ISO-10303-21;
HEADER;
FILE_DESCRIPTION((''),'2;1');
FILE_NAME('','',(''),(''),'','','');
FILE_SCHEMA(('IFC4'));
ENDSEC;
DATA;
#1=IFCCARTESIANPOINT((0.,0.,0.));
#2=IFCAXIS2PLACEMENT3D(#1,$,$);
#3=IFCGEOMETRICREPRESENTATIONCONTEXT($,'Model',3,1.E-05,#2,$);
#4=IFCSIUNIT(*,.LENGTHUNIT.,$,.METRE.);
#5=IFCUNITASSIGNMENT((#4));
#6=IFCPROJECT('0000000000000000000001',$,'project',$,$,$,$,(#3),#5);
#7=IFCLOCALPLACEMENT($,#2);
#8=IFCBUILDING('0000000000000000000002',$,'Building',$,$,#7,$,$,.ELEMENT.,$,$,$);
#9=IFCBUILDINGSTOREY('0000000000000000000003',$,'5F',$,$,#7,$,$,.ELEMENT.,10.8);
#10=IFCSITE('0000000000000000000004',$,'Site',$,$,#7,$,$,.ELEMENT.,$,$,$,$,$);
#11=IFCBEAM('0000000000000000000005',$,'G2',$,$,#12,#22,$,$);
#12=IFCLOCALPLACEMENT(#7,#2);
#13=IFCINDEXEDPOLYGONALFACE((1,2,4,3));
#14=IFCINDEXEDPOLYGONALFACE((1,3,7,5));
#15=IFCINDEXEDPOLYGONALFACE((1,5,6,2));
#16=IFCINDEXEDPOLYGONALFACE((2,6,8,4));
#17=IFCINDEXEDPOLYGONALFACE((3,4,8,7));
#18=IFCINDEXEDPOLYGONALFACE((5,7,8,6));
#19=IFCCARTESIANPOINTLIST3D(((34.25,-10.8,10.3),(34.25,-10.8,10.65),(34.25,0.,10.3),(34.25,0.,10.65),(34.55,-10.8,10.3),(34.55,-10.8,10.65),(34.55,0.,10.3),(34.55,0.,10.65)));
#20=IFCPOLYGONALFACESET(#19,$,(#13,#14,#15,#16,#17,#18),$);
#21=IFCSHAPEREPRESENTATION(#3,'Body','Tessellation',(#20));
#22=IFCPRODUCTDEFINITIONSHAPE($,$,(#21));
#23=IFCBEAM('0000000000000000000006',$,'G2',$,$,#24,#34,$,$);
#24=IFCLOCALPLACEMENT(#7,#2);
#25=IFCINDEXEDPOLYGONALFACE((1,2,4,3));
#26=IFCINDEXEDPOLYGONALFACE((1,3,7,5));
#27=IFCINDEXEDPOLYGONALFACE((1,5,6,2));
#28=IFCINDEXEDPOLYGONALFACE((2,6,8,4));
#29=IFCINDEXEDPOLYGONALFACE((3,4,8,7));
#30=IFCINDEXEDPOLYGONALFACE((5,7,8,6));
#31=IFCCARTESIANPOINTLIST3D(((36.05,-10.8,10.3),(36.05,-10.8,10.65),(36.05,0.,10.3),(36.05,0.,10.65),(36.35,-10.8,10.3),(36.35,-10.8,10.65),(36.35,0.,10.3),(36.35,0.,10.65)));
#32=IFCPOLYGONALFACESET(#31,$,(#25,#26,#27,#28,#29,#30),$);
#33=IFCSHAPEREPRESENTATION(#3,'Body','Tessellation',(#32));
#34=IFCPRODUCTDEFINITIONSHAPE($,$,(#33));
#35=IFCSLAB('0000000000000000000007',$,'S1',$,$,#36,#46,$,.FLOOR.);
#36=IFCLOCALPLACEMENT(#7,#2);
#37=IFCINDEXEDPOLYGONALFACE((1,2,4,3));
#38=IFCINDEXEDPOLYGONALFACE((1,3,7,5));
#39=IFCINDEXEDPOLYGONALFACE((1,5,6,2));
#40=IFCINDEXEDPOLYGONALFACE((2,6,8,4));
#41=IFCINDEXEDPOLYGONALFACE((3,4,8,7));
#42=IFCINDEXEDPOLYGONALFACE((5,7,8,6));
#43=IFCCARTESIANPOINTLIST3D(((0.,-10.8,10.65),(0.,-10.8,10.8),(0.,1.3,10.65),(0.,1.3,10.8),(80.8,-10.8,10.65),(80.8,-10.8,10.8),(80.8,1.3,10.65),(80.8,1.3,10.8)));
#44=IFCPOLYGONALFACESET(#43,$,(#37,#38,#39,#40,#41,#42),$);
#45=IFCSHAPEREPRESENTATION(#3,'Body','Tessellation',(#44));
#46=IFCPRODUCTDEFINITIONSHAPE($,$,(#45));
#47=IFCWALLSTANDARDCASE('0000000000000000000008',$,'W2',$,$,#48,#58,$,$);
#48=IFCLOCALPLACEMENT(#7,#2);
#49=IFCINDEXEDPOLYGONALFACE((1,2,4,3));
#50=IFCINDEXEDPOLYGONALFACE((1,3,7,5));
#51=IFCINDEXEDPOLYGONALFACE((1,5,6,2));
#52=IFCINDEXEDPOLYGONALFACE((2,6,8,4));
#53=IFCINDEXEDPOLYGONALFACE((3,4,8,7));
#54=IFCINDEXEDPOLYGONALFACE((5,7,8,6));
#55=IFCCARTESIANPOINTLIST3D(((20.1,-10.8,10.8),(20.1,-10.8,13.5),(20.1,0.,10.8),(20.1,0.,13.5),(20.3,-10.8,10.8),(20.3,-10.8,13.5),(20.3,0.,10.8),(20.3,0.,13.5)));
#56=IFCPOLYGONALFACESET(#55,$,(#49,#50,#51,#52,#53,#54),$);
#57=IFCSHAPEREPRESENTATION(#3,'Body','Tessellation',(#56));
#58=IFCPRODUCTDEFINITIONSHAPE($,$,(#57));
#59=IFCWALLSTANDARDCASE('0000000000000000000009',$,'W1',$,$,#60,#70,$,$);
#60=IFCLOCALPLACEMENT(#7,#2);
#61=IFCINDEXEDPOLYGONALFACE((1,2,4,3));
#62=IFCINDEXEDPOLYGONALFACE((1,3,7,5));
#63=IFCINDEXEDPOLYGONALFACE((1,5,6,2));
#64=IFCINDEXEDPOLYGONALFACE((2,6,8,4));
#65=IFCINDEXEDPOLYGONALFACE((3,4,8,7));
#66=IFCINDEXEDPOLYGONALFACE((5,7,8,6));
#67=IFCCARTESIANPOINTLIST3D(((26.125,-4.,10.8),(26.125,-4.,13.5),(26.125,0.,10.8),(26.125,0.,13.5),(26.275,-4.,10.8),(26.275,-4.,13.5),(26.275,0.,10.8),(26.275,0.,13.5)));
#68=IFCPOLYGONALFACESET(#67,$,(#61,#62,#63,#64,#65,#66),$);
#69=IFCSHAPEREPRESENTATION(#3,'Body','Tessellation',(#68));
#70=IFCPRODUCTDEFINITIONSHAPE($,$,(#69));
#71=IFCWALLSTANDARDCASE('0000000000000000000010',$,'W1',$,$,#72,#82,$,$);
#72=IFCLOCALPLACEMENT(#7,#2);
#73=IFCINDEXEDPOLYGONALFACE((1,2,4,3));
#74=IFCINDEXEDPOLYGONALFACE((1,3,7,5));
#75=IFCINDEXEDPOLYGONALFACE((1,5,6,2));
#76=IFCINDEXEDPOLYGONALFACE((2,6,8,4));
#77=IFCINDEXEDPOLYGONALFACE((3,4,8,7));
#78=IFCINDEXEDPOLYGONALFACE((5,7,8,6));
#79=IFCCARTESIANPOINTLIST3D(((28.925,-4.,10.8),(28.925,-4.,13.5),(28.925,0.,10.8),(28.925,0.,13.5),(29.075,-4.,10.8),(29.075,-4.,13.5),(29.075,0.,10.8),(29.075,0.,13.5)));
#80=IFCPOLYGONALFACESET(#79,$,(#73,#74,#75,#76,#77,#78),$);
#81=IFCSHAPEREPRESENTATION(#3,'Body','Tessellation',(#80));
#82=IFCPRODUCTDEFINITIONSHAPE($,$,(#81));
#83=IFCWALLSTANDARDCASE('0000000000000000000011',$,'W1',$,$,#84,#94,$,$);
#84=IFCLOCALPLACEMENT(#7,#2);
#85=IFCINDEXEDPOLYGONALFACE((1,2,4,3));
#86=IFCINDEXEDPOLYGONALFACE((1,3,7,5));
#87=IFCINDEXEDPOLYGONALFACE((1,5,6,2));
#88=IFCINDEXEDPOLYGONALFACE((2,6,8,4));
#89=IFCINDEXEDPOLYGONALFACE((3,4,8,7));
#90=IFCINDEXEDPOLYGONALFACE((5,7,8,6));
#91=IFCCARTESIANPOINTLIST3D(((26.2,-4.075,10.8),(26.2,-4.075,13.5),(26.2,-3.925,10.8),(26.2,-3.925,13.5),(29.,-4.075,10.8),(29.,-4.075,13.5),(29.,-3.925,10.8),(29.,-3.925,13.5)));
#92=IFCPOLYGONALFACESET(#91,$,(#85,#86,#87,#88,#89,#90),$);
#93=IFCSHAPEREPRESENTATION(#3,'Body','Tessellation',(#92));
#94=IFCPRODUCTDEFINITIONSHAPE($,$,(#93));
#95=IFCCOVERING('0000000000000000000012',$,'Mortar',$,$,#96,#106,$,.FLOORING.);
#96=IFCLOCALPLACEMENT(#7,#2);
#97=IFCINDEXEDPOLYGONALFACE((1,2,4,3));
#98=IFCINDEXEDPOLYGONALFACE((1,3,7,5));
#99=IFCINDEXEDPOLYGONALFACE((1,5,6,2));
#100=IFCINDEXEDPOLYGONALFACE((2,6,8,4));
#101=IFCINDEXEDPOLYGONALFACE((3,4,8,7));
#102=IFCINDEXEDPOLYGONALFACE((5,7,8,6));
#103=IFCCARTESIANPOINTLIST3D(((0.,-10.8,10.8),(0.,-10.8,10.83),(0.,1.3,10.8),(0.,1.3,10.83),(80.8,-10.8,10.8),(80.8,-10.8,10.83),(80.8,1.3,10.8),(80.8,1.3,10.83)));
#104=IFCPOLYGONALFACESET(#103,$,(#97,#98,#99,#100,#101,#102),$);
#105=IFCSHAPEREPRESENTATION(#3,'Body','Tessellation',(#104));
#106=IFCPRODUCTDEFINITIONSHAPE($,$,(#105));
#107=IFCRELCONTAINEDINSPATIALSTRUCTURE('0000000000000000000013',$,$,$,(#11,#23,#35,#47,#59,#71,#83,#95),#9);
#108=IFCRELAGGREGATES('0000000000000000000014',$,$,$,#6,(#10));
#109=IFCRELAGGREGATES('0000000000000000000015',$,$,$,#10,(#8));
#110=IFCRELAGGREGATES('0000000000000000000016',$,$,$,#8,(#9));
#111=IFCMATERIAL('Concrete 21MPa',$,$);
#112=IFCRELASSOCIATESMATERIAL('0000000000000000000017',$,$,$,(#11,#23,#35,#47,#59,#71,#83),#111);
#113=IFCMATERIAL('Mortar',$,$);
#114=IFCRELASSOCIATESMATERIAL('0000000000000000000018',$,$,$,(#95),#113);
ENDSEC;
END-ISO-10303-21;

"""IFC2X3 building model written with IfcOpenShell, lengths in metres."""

from ifc_helpers import new_model, si_unit, frame, origin, origin_2d, place, context, project, spatial, rectangle, extrude, material, element, save


model = new_model("IFC2X3")

# Units and contexts
model_context = context("Model", 3, precision=1e-05, world=origin())
ifc_project = project(units=[si_unit("LENGTHUNIT", "METRE")], contexts=[model_context])

# Site, building, storey
placement = place(None, origin())
site = spatial("IfcSite", under=ifc_project, at=placement, Name="Site", CompositionType="ELEMENT")
building = spatial("IfcBuilding", under=site, at=placement, Name="Building", CompositionType="ELEMENT")
storey = spatial("IfcBuildingStorey", under=building, at=placement, Name="5F", CompositionType="ELEMENT", Elevation=10.8)

# Shared definitions
ifc_material_1 = material(Name="Concrete 21MPa")

# Beams
for number, where, name in (
    (1, (34.4, -5.4, 10.3), "G2"),
    (2, (36.2, -5.4, 10.3), "G2"),
):
    element("IfcBeam", number, at=place(None, frame(where)), inside=storey, material=ifc_material_1, Name=name, context=model_context, shape_type="SweptSolid", body=[
        extrude(rectangle(XDim=0.3, YDim=10.8, at=origin_2d()), origin(), (0.0, 0.0, 1.0), 0.35),
    ])

# Slab
slab_placement = place(None, frame((40.4, -4.75, 10.65)))
element("IfcSlab", 3, at=slab_placement, inside=storey, material=ifc_material_1, Name="S1", PredefinedType="FLOOR", context=model_context, shape_type="SweptSolid", body=[
    extrude(rectangle(XDim=80.8, YDim=12.1, at=origin_2d()), origin(), (0.0, 0.0, 1.0), 0.15),
])

# Walls
wall_1_placement = place(None, frame((20.2, -5.4, 10.8)))
element("IfcWallStandardCase", 4, at=wall_1_placement, inside=storey, material=ifc_material_1, Name="W2", context=model_context, shape_type="SweptSolid", body=[
    extrude(rectangle(XDim=0.2, YDim=10.8, at=origin_2d()), origin(), (0.0, 0.0, 1.0), 2.7),
])
for number, where, name in (
    (5, (26.2, -2.0, 10.8), "W1"),
    (6, (29.0, -2.0, 10.8), "W1"),
):
    element("IfcWallStandardCase", number, at=place(None, frame(where)), inside=storey, material=ifc_material_1, Name=name, context=model_context, shape_type="SweptSolid", body=[
        extrude(rectangle(XDim=0.15, YDim=4.0, at=origin_2d()), origin(), (0.0, 0.0, 1.0), 2.7),
    ])
wall_2_placement = place(None, frame((27.6, -4.0, 10.8)))
element("IfcWallStandardCase", 7, at=wall_2_placement, inside=storey, material=ifc_material_1, Name="W1", context=model_context, shape_type="SweptSolid", body=[
    extrude(rectangle(XDim=2.8, YDim=0.15, at=origin_2d()), origin(), (0.0, 0.0, 1.0), 2.7),
])

# Covering
ifc_material_2 = material(Name="Mortar")
covering_placement = place(None, frame((40.4, -4.75, 10.8)))
element("IfcCovering", 8, at=covering_placement, inside=storey, material=ifc_material_2, Name="Mortar", PredefinedType="FLOORING", context=model_context, shape_type="SweptSolid", body=[
    extrude(rectangle(XDim=80.8, YDim=12.1, at=origin_2d()), origin(), (0.0, 0.0, 1.0), 0.03),
])

save(model, "model.ifc")
